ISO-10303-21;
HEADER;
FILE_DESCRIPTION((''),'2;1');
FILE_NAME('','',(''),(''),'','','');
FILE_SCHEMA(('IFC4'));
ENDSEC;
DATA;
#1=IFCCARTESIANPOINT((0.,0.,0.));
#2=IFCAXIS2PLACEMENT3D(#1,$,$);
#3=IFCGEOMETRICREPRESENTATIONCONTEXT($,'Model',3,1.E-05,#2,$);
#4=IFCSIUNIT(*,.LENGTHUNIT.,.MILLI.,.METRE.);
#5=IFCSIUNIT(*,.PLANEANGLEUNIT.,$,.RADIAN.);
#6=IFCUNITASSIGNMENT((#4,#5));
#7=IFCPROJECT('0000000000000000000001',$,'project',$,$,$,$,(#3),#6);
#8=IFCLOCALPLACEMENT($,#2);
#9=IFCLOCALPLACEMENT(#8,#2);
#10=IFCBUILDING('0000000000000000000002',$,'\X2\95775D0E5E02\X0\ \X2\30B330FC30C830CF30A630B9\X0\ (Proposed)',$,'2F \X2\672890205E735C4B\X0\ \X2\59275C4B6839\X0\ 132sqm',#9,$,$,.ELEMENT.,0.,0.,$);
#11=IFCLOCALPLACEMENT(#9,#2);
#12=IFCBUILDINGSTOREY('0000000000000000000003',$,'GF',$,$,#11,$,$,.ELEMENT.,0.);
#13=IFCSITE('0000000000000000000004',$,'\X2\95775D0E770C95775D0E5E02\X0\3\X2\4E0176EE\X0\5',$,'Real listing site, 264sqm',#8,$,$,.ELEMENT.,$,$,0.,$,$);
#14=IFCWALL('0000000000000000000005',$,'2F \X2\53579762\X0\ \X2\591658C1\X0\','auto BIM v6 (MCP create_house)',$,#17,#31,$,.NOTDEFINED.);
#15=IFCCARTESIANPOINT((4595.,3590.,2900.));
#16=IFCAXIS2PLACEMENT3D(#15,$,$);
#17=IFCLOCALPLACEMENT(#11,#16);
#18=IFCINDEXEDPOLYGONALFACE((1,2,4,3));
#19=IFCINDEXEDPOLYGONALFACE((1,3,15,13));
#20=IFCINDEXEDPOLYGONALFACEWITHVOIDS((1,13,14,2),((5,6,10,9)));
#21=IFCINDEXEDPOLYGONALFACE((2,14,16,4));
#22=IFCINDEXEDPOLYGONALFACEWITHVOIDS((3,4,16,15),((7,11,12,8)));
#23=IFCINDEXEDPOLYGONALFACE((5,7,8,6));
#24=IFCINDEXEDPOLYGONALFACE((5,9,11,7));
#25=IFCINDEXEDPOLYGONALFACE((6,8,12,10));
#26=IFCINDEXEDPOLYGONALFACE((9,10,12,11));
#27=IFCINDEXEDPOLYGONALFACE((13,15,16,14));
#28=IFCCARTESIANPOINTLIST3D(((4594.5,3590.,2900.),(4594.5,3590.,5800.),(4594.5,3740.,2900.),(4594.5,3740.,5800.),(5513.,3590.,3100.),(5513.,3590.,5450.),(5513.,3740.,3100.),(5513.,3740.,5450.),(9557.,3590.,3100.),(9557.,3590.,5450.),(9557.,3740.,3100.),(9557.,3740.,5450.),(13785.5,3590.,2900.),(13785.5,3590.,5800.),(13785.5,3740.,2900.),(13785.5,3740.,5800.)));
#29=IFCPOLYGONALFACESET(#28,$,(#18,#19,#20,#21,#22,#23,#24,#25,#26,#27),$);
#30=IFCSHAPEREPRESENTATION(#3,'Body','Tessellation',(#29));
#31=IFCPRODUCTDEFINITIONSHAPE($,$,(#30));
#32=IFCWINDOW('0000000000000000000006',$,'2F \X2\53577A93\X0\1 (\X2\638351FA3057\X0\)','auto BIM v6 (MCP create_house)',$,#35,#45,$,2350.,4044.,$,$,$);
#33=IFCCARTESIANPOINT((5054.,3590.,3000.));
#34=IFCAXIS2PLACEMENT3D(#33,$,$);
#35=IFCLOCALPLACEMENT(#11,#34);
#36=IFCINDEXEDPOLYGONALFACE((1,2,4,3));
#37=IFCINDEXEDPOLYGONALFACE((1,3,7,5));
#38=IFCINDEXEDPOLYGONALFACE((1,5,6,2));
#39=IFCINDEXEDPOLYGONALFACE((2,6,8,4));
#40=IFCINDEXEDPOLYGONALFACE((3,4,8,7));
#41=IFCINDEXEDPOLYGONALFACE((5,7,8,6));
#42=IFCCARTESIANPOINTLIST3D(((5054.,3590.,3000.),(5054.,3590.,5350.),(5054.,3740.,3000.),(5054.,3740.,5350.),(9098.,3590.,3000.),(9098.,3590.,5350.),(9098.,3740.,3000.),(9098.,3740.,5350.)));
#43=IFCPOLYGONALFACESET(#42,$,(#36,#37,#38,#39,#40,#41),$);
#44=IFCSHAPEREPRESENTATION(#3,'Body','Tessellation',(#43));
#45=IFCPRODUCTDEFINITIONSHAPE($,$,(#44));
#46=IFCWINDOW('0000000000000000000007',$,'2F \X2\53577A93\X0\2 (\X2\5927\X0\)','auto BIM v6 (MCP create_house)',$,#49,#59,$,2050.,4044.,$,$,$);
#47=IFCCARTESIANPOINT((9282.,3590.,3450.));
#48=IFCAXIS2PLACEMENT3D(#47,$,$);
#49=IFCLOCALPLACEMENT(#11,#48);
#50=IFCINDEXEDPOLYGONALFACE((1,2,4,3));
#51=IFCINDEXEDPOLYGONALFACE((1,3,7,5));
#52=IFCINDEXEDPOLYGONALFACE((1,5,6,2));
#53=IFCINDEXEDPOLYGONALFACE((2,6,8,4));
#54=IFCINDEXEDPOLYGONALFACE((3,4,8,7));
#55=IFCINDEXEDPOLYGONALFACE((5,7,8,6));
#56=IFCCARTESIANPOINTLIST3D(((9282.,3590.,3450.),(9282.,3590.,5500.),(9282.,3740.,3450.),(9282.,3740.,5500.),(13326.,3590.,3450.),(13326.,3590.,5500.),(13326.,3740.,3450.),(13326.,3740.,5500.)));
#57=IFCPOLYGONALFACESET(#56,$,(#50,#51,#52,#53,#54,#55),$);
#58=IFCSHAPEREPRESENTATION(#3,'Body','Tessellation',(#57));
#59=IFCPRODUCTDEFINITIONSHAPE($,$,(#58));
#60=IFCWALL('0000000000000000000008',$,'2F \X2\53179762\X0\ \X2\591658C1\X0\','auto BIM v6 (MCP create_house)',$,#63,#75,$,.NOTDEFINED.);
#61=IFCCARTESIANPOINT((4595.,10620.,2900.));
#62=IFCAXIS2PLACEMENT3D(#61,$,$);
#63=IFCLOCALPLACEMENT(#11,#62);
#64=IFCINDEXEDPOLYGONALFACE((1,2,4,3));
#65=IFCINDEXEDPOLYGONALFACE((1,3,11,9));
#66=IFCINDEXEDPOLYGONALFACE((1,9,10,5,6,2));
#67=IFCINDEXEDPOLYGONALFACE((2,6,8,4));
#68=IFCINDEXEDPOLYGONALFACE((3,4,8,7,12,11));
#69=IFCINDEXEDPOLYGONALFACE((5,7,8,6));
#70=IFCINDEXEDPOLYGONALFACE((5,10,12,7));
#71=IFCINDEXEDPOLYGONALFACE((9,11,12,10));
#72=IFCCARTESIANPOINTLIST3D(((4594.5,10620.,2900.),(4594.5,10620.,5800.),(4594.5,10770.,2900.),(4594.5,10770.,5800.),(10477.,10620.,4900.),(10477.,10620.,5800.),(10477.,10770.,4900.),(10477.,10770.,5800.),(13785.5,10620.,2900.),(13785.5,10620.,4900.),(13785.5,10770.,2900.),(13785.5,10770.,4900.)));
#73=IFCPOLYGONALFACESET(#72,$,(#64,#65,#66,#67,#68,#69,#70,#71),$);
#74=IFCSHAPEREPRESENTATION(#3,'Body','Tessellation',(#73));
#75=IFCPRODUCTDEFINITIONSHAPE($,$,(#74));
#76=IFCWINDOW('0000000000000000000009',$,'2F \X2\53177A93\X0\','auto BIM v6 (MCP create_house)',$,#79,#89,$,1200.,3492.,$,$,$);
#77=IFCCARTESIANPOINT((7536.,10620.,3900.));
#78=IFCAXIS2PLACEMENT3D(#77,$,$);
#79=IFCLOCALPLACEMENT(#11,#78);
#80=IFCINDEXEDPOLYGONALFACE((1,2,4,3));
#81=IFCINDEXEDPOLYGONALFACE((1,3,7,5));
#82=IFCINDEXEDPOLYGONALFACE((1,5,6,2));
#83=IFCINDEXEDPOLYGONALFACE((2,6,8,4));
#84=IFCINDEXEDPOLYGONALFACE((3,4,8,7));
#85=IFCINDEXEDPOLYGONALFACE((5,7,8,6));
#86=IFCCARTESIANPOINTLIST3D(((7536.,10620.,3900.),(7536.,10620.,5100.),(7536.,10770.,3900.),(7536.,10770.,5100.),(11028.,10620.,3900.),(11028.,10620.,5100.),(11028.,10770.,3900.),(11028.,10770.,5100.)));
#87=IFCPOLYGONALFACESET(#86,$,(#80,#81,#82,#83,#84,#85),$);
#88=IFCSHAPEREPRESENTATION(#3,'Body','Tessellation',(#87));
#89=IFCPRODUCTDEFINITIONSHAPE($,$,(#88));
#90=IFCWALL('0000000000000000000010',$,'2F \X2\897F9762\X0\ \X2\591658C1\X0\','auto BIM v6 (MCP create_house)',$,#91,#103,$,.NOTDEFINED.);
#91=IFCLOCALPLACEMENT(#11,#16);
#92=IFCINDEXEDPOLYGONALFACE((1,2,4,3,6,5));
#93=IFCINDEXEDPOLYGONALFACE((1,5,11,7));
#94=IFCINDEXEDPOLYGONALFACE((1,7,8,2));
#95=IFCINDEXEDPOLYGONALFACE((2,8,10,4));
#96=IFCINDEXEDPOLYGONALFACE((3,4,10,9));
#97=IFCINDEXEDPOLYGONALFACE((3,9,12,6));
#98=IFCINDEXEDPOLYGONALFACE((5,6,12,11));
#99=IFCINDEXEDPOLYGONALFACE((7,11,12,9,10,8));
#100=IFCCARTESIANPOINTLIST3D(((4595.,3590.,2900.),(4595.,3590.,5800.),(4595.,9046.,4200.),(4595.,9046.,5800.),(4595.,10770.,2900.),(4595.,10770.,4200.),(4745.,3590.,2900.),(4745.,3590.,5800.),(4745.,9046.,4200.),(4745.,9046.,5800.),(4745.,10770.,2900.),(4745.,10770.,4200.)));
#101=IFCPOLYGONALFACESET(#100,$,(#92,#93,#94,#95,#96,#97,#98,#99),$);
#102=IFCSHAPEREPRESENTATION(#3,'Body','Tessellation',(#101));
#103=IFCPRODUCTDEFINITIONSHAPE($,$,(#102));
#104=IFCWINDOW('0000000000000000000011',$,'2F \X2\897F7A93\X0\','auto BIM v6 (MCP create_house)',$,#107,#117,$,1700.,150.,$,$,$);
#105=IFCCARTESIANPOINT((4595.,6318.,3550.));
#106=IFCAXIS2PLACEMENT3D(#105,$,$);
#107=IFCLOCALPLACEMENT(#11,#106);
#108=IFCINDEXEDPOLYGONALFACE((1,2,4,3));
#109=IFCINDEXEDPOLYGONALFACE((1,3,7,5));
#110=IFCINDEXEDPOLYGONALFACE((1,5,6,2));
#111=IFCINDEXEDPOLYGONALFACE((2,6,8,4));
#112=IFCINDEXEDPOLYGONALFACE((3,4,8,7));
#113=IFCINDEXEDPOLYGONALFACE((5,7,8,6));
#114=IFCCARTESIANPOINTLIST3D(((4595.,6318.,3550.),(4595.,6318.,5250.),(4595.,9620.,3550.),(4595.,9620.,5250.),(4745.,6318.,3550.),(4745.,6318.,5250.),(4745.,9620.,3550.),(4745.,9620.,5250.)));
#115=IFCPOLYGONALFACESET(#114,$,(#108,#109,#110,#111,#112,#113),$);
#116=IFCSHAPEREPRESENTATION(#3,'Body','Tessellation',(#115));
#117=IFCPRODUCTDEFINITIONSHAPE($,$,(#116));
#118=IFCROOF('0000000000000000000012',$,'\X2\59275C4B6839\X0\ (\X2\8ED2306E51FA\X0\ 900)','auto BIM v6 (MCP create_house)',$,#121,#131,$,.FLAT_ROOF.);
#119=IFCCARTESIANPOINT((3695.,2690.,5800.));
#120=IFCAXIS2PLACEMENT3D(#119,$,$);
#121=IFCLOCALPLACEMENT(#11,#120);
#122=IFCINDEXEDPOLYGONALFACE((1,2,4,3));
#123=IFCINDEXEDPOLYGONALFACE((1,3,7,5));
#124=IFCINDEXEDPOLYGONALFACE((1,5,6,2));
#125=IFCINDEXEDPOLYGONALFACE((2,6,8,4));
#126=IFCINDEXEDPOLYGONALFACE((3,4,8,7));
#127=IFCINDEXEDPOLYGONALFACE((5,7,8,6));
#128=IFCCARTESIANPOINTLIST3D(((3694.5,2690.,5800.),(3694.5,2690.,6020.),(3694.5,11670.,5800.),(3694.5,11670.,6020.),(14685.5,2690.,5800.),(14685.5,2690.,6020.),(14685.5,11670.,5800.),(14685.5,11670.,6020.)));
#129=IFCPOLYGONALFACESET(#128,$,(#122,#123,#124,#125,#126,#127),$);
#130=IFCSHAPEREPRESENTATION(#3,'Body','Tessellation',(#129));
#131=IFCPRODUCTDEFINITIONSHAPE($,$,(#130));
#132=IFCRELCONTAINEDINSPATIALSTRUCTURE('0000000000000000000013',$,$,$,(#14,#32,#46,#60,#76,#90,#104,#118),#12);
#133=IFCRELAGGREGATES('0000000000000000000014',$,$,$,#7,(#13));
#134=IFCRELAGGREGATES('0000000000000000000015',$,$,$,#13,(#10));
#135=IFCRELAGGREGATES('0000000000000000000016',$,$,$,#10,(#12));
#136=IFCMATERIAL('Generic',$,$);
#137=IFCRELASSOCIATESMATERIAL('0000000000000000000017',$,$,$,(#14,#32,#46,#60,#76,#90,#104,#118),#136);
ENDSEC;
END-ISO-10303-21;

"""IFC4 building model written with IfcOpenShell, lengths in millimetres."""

from ifc_helpers import new_model, si_unit, frame, frame_2d, origin, place, context, project, spatial, rectangle, extrude, material, element, fill, save


model = new_model("IFC4")

# Units and contexts
model_context = context("Model", 3, precision=1e-05, world=origin())
ifc_project = project(units=[si_unit("LENGTHUNIT", "METRE", prefix="MILLI"), si_unit("PLANEANGLEUNIT", "RADIAN")], contexts=[model_context])

# Site, building, storey
site_placement = place(None, origin())
site = spatial("IfcSite", under=ifc_project, at=site_placement, Name="長崎県長崎市3丁目5", ObjectType="Real listing site, 264sqm", CompositionType="ELEMENT", RefElevation=0.0)
building_placement = place(site_placement, origin())
building = spatial("IfcBuilding", under=site, at=building_placement, Name="長崎市 コートハウス (Proposed)", ObjectType="2F 木造平屋 大屋根 132sqm", CompositionType="ELEMENT", ElevationOfRefHeight=0.0, ElevationOfTerrain=0.0)
storey_placement = place(building_placement, origin())
storey = spatial("IfcBuildingStorey", under=building, at=storey_placement, Name="GF", CompositionType="ELEMENT", Elevation=0.0)

# Shared definitions
ifc_material = material(Name="Generic")

# Wall, openings, windows
wall_1_placement = place(storey_placement, frame((4595.0, 3590.0, 2900.0)))
wall_1 = element("IfcWall", 1, at=wall_1_placement, inside=storey, material=ifc_material, Name="2F 南面 外壁", Description="auto BIM v6 (MCP create_house)", PredefinedType="NOTDEFINED", context=model_context, shape_type="SweptSolid", body=[
    extrude(rectangle(XDim=9191.0, YDim=150.0, at=frame_2d((4595.0, 75.0))), frame((4595.0, 3590.0, 2900.0)), (0.0, 0.0, 1.0), 2900.0),
])
opening_1_placement = place(storey_placement, frame((5054.0, 3590.0, 3000.0)))
opening_1 = element("IfcOpeningElement", 2, at=opening_1_placement, cuts=wall_1, PredefinedType="NOTDEFINED", context=model_context, shape_type="SweptSolid", body=[
    extrude(rectangle(XDim=4044.0, YDim=150.0, at=frame_2d((2022.0, 75.0))), frame((5054.0, 3590.0, 3000.0)), (0.0, 0.0, 1.0), 2350.0),
])
opening_2_placement = place(storey_placement, frame((9282.0, 3590.0, 3450.0)))
opening_2 = element("IfcOpeningElement", 3, at=opening_2_placement, cuts=wall_1, PredefinedType="NOTDEFINED", context=model_context, shape_type="SweptSolid", body=[
    extrude(rectangle(XDim=4044.0, YDim=150.0, at=frame_2d((2022.0, 75.0))), frame((9282.0, 3590.0, 3450.0)), (0.0, 0.0, 1.0), 2050.0),
])
window_1_placement = place(storey_placement, frame((5054.0, 3590.0, 3000.0)))
window_1 = element("IfcWindow", 4, at=window_1_placement, inside=storey, material=ifc_material, Name="2F 南窓1 (掃出し)", Description="auto BIM v6 (MCP create_house)", OverallHeight=2350.0, OverallWidth=4044.0, context=model_context, shape_type="SweptSolid", body=[
    extrude(rectangle(XDim=4044.0, YDim=150.0, at=frame_2d((2022.0, 75.0))), frame((5054.0, 3590.0, 3000.0)), (0.0, 0.0, 1.0), 2350.0),
])
fill(opening_1, window_1)
window_2_placement = place(storey_placement, frame((9282.0, 3590.0, 3450.0)))
window_2 = element("IfcWindow", 5, at=window_2_placement, inside=storey, material=ifc_material, Name="2F 南窓2 (大)", Description="auto BIM v6 (MCP create_house)", OverallHeight=2050.0, OverallWidth=4044.0, context=model_context, shape_type="SweptSolid", body=[
    extrude(rectangle(XDim=4044.0, YDim=150.0, at=frame_2d((2022.0, 75.0))), frame((9282.0, 3590.0, 3450.0)), (0.0, 0.0, 1.0), 2050.0),
])
fill(opening_2, window_2)

# Walls, openings, windows
wall_2_placement = place(storey_placement, frame((4595.0, 10620.0, 2900.0)))
wall_2 = element("IfcWall", 6, at=wall_2_placement, inside=storey, material=ifc_material, Name="2F 北面 外壁", Description="auto BIM v6 (MCP create_house)", PredefinedType="NOTDEFINED", context=model_context, shape_type="SweptSolid", body=[
    extrude(rectangle(XDim=9191.0, YDim=150.0, at=frame_2d((4595.0, 75.0))), frame((4595.0, 10620.0, 2900.0)), (0.0, 0.0, 1.0), 2900.0),
])
opening_3_placement = place(storey_placement, frame((7536.0, 10620.0, 3900.0)))
opening_3 = element("IfcOpeningElement", 7, at=opening_3_placement, cuts=wall_2, PredefinedType="NOTDEFINED", context=model_context, shape_type="SweptSolid", body=[
    extrude(rectangle(XDim=3492.0, YDim=150.0, at=frame_2d((1746.0, 75.0))), frame((7536.0, 10620.0, 3900.0)), (0.0, 0.0, 1.0), 1200.0),
])
window_3_placement = place(storey_placement, frame((7536.0, 10620.0, 3900.0)))
window_3 = element("IfcWindow", 8, at=window_3_placement, inside=storey, material=ifc_material, Name="2F 北窓", Description="auto BIM v6 (MCP create_house)", OverallHeight=1200.0, OverallWidth=3492.0, context=model_context, shape_type="SweptSolid", body=[
    extrude(rectangle(XDim=3492.0, YDim=150.0, at=frame_2d((1746.0, 75.0))), frame((7536.0, 10620.0, 3900.0)), (0.0, 0.0, 1.0), 1200.0),
])
fill(opening_3, window_3)
wall_3_placement = place(storey_placement, frame((4595.0, 3590.0, 2900.0)))
wall_3 = element("IfcWall", 9, at=wall_3_placement, inside=storey, material=ifc_material, Name="2F 西面 外壁", Description="auto BIM v6 (MCP create_house)", PredefinedType="NOTDEFINED", context=model_context, shape_type="SweptSolid", body=[
    extrude(rectangle(XDim=150.0, YDim=7180.0, at=frame_2d((75.0, 3590.0))), frame((4595.0, 3590.0, 2900.0)), (0.0, 0.0, 1.0), 2900.0),
])
opening_4_placement = place(storey_placement, frame((4595.0, 6318.0, 3550.0)))
opening_4 = element("IfcOpeningElement", 10, at=opening_4_placement, cuts=wall_3, PredefinedType="NOTDEFINED", context=model_context, shape_type="SweptSolid", body=[
    extrude(rectangle(XDim=150.0, YDim=3302.0, at=frame_2d((75.0, 1651.0))), frame((4595.0, 6318.0, 3550.0)), (0.0, 0.0, 1.0), 1700.0),
])
window_4_placement = place(storey_placement, frame((4595.0, 6318.0, 3550.0)))
window_4 = element("IfcWindow", 11, at=window_4_placement, inside=storey, material=ifc_material, Name="2F 西窓", Description="auto BIM v6 (MCP create_house)", OverallHeight=1700.0, OverallWidth=150.0, context=model_context, shape_type="SweptSolid", body=[
    extrude(rectangle(XDim=150.0, YDim=3302.0, at=frame_2d((75.0, 1651.0))), frame((4595.0, 6318.0, 3550.0)), (0.0, 0.0, 1.0), 1700.0),
])
fill(opening_4, window_4)

# Roof
roof_placement = place(storey_placement, frame((3695.0, 2690.0, 5800.0)))
element("IfcRoof", 12, at=roof_placement, inside=storey, material=ifc_material, Name="大屋根 (軒の出 900)", Description="auto BIM v6 (MCP create_house)", PredefinedType="FLAT_ROOF", context=model_context, shape_type="SweptSolid", body=[
    extrude(rectangle(XDim=10991.0, YDim=8980.0, at=frame_2d((5495.0, 4490.0))), frame((3695.0, 2690.0, 5800.0)), (0.0, 0.0, 1.0), 220.0),
])

save(model, "model.ifc")
